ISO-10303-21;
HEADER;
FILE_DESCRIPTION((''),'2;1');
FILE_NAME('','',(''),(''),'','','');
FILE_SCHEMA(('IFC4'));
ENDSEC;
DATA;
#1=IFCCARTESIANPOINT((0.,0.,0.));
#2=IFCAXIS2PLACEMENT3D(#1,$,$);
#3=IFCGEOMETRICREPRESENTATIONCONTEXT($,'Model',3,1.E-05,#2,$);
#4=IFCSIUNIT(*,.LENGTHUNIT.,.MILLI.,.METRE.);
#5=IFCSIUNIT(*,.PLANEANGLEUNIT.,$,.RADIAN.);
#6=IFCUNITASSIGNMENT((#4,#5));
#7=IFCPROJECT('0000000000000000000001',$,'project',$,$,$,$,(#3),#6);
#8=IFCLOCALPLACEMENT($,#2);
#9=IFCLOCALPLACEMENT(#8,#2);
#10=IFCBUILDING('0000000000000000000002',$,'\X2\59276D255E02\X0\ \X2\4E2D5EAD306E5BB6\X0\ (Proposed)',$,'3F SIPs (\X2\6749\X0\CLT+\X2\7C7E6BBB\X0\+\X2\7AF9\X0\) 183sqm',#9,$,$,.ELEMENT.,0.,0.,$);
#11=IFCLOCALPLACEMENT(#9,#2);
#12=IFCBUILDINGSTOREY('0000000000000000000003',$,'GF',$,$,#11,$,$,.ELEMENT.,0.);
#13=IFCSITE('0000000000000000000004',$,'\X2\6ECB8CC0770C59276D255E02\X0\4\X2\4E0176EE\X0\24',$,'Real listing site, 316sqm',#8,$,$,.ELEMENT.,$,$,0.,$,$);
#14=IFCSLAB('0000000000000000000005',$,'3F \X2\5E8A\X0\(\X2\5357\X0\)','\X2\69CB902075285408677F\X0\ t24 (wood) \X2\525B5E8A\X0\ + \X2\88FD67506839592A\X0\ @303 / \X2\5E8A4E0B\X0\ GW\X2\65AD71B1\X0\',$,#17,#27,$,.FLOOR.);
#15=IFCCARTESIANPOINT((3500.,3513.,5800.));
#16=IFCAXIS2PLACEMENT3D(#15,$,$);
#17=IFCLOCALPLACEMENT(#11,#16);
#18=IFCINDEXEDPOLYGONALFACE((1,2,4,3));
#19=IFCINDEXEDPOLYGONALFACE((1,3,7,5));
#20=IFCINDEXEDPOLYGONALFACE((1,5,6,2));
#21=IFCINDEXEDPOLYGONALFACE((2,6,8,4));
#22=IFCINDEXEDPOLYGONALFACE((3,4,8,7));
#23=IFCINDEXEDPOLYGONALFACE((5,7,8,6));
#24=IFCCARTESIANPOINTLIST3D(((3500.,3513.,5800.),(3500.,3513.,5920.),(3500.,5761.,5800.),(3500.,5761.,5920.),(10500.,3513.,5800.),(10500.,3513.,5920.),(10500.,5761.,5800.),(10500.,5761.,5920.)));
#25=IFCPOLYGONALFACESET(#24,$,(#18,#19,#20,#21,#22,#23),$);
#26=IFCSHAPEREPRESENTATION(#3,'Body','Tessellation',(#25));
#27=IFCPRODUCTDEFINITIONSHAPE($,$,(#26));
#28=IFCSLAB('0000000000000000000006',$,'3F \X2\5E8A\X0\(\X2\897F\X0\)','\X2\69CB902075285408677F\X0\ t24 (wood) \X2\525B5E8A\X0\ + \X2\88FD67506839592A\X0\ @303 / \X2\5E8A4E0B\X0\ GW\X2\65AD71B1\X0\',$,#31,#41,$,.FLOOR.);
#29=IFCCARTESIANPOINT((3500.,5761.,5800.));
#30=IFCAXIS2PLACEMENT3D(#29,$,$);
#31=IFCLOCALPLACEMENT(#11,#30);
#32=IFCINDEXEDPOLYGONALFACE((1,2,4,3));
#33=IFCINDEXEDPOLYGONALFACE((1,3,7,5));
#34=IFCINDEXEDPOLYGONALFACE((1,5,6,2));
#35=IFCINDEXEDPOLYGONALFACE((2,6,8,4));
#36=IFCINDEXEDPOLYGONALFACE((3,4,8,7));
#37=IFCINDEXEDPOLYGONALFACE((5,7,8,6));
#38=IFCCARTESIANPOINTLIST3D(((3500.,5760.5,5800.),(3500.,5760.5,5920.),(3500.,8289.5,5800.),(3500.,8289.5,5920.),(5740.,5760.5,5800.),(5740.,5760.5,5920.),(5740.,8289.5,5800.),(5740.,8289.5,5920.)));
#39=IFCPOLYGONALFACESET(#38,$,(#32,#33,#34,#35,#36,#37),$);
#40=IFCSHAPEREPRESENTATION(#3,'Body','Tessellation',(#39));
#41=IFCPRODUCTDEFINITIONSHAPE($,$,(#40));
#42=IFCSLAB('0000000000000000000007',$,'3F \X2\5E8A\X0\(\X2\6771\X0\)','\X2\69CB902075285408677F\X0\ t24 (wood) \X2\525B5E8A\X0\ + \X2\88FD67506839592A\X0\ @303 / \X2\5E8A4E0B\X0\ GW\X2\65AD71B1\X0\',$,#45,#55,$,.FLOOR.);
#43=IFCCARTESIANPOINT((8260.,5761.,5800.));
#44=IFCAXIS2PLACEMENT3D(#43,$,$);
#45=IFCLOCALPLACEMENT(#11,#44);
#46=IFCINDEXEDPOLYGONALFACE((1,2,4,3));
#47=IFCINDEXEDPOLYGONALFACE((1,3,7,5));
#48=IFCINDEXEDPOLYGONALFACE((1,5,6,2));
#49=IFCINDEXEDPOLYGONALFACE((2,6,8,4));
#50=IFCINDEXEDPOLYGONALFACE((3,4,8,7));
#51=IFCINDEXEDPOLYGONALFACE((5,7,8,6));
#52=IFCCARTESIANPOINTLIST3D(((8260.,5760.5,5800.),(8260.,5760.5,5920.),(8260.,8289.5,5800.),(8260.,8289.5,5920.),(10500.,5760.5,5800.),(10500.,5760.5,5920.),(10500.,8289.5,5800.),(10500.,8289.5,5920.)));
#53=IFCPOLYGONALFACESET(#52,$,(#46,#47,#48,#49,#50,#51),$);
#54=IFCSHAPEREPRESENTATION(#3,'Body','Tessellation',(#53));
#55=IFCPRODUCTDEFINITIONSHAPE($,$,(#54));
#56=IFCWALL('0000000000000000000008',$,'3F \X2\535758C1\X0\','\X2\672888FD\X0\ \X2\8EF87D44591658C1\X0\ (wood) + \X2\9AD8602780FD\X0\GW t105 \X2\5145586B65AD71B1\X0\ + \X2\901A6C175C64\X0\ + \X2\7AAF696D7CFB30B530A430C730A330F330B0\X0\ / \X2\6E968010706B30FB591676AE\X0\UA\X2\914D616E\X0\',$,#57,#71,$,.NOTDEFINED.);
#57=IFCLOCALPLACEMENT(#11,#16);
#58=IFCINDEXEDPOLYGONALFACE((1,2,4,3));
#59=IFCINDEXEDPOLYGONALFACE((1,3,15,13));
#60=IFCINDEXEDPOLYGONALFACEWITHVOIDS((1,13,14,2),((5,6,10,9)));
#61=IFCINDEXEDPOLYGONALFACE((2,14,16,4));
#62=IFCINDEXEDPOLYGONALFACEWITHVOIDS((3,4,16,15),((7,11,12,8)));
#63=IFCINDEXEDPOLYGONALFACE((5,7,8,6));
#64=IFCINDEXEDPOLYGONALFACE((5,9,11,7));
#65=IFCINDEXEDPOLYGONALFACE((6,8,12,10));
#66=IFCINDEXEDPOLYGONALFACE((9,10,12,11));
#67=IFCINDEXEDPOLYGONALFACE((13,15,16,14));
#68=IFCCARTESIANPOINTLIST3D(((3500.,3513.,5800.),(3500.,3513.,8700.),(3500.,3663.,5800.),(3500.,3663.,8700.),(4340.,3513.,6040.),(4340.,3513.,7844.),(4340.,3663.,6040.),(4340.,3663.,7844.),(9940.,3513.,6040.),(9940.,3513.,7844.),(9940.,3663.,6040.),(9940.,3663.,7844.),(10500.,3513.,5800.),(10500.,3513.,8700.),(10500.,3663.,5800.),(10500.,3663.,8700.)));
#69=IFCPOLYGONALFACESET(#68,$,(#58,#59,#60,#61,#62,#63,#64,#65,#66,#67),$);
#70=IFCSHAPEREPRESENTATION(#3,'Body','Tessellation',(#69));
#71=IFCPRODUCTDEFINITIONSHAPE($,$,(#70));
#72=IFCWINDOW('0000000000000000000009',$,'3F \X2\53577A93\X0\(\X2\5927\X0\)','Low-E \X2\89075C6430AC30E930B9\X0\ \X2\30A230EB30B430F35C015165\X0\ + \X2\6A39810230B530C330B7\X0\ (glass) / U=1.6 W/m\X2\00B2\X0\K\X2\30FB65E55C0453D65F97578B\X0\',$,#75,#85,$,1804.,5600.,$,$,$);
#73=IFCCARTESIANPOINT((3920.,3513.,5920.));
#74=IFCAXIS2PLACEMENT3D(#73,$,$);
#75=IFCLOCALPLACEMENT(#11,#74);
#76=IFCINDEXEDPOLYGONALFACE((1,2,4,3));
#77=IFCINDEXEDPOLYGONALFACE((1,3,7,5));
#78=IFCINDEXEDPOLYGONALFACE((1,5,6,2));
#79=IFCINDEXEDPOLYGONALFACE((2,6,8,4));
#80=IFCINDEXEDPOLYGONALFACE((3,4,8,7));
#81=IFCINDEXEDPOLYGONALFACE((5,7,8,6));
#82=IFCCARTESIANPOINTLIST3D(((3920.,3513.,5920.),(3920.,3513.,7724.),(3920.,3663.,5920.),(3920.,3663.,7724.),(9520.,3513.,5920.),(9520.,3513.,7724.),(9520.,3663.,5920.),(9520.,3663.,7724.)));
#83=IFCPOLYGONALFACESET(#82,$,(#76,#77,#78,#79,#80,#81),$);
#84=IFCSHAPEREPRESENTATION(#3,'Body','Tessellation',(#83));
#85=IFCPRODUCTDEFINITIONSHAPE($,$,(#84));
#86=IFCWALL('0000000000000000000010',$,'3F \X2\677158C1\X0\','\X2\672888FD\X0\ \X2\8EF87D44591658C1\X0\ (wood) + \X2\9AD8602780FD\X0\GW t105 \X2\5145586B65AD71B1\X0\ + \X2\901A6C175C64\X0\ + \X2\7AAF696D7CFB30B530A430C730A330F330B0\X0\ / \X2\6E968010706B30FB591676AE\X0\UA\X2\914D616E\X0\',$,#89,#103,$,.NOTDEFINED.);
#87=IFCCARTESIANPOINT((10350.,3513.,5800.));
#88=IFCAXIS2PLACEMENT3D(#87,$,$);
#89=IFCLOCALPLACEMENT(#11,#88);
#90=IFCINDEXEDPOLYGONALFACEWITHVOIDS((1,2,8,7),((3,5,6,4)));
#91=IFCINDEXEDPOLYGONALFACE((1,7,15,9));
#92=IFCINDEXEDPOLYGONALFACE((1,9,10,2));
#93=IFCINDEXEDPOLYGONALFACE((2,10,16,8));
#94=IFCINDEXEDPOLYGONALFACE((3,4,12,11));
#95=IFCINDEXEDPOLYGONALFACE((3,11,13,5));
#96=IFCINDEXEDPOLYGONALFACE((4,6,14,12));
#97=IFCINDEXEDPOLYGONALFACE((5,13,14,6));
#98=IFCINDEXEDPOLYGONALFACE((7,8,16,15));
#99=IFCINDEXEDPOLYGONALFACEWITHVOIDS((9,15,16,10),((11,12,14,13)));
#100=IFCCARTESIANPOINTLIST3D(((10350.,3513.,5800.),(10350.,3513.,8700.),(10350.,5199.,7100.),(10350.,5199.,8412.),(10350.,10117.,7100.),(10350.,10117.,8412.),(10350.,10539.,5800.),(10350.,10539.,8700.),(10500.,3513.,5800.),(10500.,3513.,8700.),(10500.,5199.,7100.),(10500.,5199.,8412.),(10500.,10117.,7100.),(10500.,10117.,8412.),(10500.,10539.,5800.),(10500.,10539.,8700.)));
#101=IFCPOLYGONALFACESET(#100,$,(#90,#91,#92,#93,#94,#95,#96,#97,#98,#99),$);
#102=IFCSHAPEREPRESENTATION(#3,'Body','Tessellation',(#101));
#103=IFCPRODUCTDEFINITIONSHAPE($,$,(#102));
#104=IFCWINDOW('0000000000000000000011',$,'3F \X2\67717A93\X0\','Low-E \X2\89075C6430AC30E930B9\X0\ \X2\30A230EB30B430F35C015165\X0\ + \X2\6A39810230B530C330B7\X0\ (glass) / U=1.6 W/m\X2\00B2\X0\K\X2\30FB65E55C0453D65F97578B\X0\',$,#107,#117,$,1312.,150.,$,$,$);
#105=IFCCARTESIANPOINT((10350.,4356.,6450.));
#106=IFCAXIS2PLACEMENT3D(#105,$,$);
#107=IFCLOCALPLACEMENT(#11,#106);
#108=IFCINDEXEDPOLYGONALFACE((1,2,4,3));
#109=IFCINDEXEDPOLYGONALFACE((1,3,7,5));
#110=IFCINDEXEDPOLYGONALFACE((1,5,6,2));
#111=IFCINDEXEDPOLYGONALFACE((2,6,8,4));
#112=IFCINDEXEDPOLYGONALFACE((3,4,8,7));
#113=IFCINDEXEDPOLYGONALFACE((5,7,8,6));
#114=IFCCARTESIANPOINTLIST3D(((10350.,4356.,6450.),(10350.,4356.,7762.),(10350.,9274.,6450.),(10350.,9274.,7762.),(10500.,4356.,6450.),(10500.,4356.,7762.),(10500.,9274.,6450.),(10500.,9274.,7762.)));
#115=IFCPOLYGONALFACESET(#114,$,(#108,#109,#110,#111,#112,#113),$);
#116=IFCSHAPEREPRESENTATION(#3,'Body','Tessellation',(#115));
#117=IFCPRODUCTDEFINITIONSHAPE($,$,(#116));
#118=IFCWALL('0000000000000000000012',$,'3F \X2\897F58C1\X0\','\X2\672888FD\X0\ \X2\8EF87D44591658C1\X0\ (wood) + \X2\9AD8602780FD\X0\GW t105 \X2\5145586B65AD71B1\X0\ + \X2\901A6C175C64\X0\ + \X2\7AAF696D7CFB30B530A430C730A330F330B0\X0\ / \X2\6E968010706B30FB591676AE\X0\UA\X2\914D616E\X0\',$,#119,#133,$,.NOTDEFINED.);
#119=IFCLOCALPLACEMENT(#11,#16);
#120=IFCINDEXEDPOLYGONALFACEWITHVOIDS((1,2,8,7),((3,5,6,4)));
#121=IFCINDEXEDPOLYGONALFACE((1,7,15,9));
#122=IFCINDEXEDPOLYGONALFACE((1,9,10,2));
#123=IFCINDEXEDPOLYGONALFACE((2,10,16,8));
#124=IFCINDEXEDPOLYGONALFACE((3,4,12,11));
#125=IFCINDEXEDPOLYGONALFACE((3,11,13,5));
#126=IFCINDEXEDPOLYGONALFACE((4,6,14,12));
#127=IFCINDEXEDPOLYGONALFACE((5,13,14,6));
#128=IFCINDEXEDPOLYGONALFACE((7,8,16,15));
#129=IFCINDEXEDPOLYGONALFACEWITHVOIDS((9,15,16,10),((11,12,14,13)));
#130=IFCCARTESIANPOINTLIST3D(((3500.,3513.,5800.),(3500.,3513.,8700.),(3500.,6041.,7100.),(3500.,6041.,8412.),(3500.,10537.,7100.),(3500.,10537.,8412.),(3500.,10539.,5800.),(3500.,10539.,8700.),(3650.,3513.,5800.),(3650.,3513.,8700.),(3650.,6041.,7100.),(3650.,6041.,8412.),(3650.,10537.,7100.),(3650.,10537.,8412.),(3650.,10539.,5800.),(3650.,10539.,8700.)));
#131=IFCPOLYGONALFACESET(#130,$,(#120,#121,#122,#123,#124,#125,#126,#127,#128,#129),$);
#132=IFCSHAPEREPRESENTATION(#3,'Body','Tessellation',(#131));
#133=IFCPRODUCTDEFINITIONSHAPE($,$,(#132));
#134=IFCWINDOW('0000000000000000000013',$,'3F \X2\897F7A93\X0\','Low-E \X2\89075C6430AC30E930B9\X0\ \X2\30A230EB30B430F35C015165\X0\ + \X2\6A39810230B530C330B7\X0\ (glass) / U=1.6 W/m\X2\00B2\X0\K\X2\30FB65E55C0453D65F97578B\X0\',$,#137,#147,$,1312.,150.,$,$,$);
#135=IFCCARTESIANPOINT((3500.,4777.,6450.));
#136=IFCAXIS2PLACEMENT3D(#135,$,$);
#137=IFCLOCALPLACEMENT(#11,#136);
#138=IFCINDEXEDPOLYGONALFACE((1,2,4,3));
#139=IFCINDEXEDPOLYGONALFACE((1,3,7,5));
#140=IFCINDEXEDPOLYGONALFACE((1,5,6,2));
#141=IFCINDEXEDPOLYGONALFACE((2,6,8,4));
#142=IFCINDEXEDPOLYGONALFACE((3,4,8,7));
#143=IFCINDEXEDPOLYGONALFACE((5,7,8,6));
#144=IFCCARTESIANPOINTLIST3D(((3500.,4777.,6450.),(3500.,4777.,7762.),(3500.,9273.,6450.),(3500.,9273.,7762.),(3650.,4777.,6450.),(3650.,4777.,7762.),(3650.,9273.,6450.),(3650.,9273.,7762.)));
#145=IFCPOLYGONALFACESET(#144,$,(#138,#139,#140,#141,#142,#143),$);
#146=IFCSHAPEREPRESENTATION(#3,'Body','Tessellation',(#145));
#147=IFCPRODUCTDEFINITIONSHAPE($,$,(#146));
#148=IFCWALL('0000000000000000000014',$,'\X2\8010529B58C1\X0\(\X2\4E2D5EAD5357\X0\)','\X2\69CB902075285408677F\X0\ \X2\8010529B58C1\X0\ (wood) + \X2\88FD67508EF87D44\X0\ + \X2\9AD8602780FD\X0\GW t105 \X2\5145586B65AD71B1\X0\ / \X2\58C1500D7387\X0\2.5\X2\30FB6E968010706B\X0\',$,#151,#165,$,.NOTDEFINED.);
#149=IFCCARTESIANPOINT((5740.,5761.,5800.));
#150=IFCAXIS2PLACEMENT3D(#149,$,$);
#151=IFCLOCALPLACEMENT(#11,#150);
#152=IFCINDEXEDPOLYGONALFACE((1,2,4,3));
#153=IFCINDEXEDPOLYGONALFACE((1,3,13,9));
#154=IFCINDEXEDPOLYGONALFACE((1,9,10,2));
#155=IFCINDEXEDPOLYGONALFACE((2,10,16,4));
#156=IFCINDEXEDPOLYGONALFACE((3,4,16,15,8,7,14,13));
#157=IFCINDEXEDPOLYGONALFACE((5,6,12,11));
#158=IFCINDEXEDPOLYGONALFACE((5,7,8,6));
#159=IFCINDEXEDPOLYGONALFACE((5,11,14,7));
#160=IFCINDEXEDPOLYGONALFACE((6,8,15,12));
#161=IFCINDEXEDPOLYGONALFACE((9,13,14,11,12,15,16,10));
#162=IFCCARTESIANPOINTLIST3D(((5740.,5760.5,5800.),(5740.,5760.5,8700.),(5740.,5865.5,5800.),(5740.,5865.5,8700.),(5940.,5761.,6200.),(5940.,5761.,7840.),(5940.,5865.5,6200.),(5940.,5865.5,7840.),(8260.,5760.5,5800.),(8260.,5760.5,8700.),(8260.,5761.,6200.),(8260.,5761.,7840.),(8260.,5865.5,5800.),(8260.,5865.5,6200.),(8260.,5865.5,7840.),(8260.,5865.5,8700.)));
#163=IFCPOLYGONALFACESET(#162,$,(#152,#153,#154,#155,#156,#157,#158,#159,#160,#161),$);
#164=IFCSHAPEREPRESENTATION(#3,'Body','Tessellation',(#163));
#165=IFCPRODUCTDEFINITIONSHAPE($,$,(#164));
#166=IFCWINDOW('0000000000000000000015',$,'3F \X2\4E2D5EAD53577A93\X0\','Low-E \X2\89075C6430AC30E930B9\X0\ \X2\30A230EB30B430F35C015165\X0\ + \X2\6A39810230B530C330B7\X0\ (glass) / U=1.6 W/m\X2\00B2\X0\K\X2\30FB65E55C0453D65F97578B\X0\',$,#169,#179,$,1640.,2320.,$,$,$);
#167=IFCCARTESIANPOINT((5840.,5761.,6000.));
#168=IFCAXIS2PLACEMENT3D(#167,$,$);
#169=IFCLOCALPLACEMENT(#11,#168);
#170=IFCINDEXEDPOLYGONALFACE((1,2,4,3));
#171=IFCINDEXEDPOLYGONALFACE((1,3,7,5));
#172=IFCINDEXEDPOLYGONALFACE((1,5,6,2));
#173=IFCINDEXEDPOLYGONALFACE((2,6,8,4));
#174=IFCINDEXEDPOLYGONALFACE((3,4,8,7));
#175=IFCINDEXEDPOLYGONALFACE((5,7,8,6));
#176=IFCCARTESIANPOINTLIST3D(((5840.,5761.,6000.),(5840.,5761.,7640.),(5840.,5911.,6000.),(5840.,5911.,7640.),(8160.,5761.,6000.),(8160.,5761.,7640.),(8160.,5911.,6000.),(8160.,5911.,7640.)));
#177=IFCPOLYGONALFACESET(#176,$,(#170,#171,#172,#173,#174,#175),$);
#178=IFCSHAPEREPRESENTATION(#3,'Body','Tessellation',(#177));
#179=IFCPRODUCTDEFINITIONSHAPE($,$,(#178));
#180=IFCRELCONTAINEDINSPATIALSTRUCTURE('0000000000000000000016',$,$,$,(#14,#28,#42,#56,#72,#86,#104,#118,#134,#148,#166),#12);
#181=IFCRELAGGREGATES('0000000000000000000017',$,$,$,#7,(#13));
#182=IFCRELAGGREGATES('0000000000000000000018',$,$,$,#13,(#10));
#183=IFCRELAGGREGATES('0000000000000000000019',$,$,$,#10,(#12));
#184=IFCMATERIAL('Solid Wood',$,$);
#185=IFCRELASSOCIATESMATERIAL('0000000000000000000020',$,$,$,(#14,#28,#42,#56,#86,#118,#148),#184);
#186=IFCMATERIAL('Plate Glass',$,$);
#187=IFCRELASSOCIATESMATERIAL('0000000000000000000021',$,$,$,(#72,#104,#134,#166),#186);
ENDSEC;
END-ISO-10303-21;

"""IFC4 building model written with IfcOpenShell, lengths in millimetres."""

from ifc_helpers import new_model, si_unit, frame, frame_2d, origin, place, context, project, spatial, rectangle, extrude, material, element, fill, save


model = new_model("IFC4")

# Units and contexts
model_context = context("Model", 3, precision=1e-05, world=origin())
ifc_project = project(units=[si_unit("LENGTHUNIT", "METRE", prefix="MILLI"), si_unit("PLANEANGLEUNIT", "RADIAN")], contexts=[model_context])

# Site, building, storey
site_placement = place(None, origin())
site = spatial("IfcSite", under=ifc_project, at=site_placement, Name="滋賀県大津市4丁目24", ObjectType="Real listing site, 316sqm", CompositionType="ELEMENT", RefElevation=0.0)
building_placement = place(site_placement, origin())
building = spatial("IfcBuilding", under=site, at=building_placement, Name="大津市 中庭の家 (Proposed)", ObjectType="3F SIPs (杉CLT+籾殻+竹) 183sqm", CompositionType="ELEMENT", ElevationOfRefHeight=0.0, ElevationOfTerrain=0.0)
storey_placement = place(building_placement, origin())
storey = spatial("IfcBuildingStorey", under=building, at=storey_placement, Name="GF", CompositionType="ELEMENT", Elevation=0.0)

# Slabs
ifc_material_1 = material(Name="Solid Wood")
slab_1_placement = place(storey_placement, frame((3500.0, 3513.0, 5800.0)))
element("IfcSlab", 1, at=slab_1_placement, inside=storey, material=ifc_material_1, Name="3F 床(南)", Description="構造用合板 t24 (wood) 剛床 + 製材根太 @303 / 床下 GW断熱", PredefinedType="FLOOR", context=model_context, shape_type="SweptSolid", body=[
    extrude(rectangle(XDim=7000.0, YDim=2248.0, at=frame_2d((3500.0, 1124.0))), frame((3500.0, 3513.0, 5800.0)), (0.0, 0.0, 1.0), 120.0),
])
slab_2_placement = place(storey_placement, frame((3500.0, 5761.0, 5800.0)))
element("IfcSlab", 2, at=slab_2_placement, inside=storey, material=ifc_material_1, Name="3F 床(西)", Description="構造用合板 t24 (wood) 剛床 + 製材根太 @303 / 床下 GW断熱", PredefinedType="FLOOR", context=model_context, shape_type="SweptSolid", body=[
    extrude(rectangle(XDim=2240.0, YDim=2529.0, at=frame_2d((1120.0, 1264.0))), frame((3500.0, 5761.0, 5800.0)), (0.0, 0.0, 1.0), 120.0),
])
slab_3_placement = place(storey_placement, frame((8260.0, 5761.0, 5800.0)))
element("IfcSlab", 3, at=slab_3_placement, inside=storey, material=ifc_material_1, Name="3F 床(東)", Description="構造用合板 t24 (wood) 剛床 + 製材根太 @303 / 床下 GW断熱", PredefinedType="FLOOR", context=model_context, shape_type="SweptSolid", body=[
    extrude(rectangle(XDim=2240.0, YDim=2529.0, at=frame_2d((1120.0, 1264.0))), frame((8260.0, 5761.0, 5800.0)), (0.0, 0.0, 1.0), 120.0),
])

# Walls, openings, windows
wall_1_placement = place(storey_placement, frame((3500.0, 3513.0, 5800.0)))
wall_1 = element("IfcWall", 4, at=wall_1_placement, inside=storey, material=ifc_material_1, Name="3F 南壁", Description="木製 軸組外壁 (wood) + 高性能GW t105 充填断熱 + 通気層 + 窯業系サイディング / 準耐火・外皮UA配慮", PredefinedType="NOTDEFINED", context=model_context, shape_type="SweptSolid", body=[
    extrude(rectangle(XDim=7000.0, YDim=150.0, at=frame_2d((3500.0, 75.0))), frame((3500.0, 3513.0, 5800.0)), (0.0, 0.0, 1.0), 2900.0),
])
opening_1_placement = place(storey_placement, frame((3920.0, 3513.0, 5920.0)))
opening_1 = element("IfcOpeningElement", 5, at=opening_1_placement, cuts=wall_1, PredefinedType="NOTDEFINED", context=model_context, shape_type="SweptSolid", body=[
    extrude(rectangle(XDim=5600.0, YDim=150.0, at=frame_2d((2800.0, 75.0))), frame((3920.0, 3513.0, 5920.0)), (0.0, 0.0, 1.0), 1804.0),
])
ifc_material_2 = material(Name="Plate Glass")
window_1_placement = place(storey_placement, frame((3920.0, 3513.0, 5920.0)))
window_1 = element("IfcWindow", 6, at=window_1_placement, inside=storey, material=ifc_material_2, Name="3F 南窓(大)", Description="Low-E 複層ガラス アルゴン封入 + 樹脂サッシ (glass) / U=1.6 W/m²K・日射取得型", OverallHeight=1804.0, OverallWidth=5600.0, context=model_context, shape_type="SweptSolid", body=[
    extrude(rectangle(XDim=5600.0, YDim=150.0, at=frame_2d((2800.0, 75.0))), frame((3920.0, 3513.0, 5920.0)), (0.0, 0.0, 1.0), 1804.0),
])
fill(opening_1, window_1)
wall_2_placement = place(storey_placement, frame((10350.0, 3513.0, 5800.0)))
wall_2 = element("IfcWall", 7, at=wall_2_placement, inside=storey, material=ifc_material_1, Name="3F 東壁", Description="木製 軸組外壁 (wood) + 高性能GW t105 充填断熱 + 通気層 + 窯業系サイディング / 準耐火・外皮UA配慮", PredefinedType="NOTDEFINED", context=model_context, shape_type="SweptSolid", body=[
    extrude(rectangle(XDim=150.0, YDim=7026.0, at=frame_2d((75.0, 3513.0))), frame((10350.0, 3513.0, 5800.0)), (0.0, 0.0, 1.0), 2900.0),
])
opening_2_placement = place(storey_placement, frame((10350.0, 4356.0, 6450.0)))
opening_2 = element("IfcOpeningElement", 8, at=opening_2_placement, cuts=wall_2, PredefinedType="NOTDEFINED", context=model_context, shape_type="SweptSolid", body=[
    extrude(rectangle(XDim=150.0, YDim=4918.0, at=frame_2d((75.0, 2459.0))), frame((10350.0, 4356.0, 6450.0)), (0.0, 0.0, 1.0), 1312.0),
])
window_2_placement = place(storey_placement, frame((10350.0, 4356.0, 6450.0)))
window_2 = element("IfcWindow", 9, at=window_2_placement, inside=storey, material=ifc_material_2, Name="3F 東窓", Description="Low-E 複層ガラス アルゴン封入 + 樹脂サッシ (glass) / U=1.6 W/m²K・日射取得型", OverallHeight=1312.0, OverallWidth=150.0, context=model_context, shape_type="SweptSolid", body=[
    extrude(rectangle(XDim=150.0, YDim=4918.0, at=frame_2d((75.0, 2459.0))), frame((10350.0, 4356.0, 6450.0)), (0.0, 0.0, 1.0), 1312.0),
])
fill(opening_2, window_2)
wall_3_placement = place(storey_placement, frame((3500.0, 3513.0, 5800.0)))
wall_3 = element("IfcWall", 10, at=wall_3_placement, inside=storey, material=ifc_material_1, Name="3F 西壁", Description="木製 軸組外壁 (wood) + 高性能GW t105 充填断熱 + 通気層 + 窯業系サイディング / 準耐火・外皮UA配慮", PredefinedType="NOTDEFINED", context=model_context, shape_type="SweptSolid", body=[
    extrude(rectangle(XDim=150.0, YDim=7026.0, at=frame_2d((75.0, 3513.0))), frame((3500.0, 3513.0, 5800.0)), (0.0, 0.0, 1.0), 2900.0),
])
opening_3_placement = place(storey_placement, frame((3500.0, 4777.0, 6450.0)))
opening_3 = element("IfcOpeningElement", 11, at=opening_3_placement, cuts=wall_3, PredefinedType="NOTDEFINED", context=model_context, shape_type="SweptSolid", body=[
    extrude(rectangle(XDim=150.0, YDim=4496.0, at=frame_2d((75.0, 2248.0))), frame((3500.0, 4777.0, 6450.0)), (0.0, 0.0, 1.0), 1312.0),
])
window_3_placement = place(storey_placement, frame((3500.0, 4777.0, 6450.0)))
window_3 = element("IfcWindow", 12, at=window_3_placement, inside=storey, material=ifc_material_2, Name="3F 西窓", Description="Low-E 複層ガラス アルゴン封入 + 樹脂サッシ (glass) / U=1.6 W/m²K・日射取得型", OverallHeight=1312.0, OverallWidth=150.0, context=model_context, shape_type="SweptSolid", body=[
    extrude(rectangle(XDim=150.0, YDim=4496.0, at=frame_2d((75.0, 2248.0))), frame((3500.0, 4777.0, 6450.0)), (0.0, 0.0, 1.0), 1312.0),
])
fill(opening_3, window_3)
wall_4_placement = place(storey_placement, frame((5740.0, 5761.0, 5800.0)))
wall_4 = element("IfcWall", 13, at=wall_4_placement, inside=storey, material=ifc_material_1, Name="耐力壁(中庭南)", Description="構造用合板 耐力壁 (wood) + 製材軸組 + 高性能GW t105 充填断熱 / 壁倍率2.5・準耐火", PredefinedType="NOTDEFINED", context=model_context, shape_type="SweptSolid", body=[
    extrude(rectangle(XDim=2520.0, YDim=105.0, at=frame_2d((1260.0, 52.0))), frame((5740.0, 5761.0, 5800.0)), (0.0, 0.0, 1.0), 2900.0),
])
opening_4_placement = place(storey_placement, frame((5840.0, 5761.0, 6000.0)))
opening_4 = element("IfcOpeningElement", 14, at=opening_4_placement, cuts=wall_4, PredefinedType="NOTDEFINED", context=model_context, shape_type="SweptSolid", body=[
    extrude(rectangle(XDim=2320.0, YDim=150.0, at=frame_2d((1160.0, 75.0))), frame((5840.0, 5761.0, 6000.0)), (0.0, 0.0, 1.0), 1640.0),
])
window_4_placement = place(storey_placement, frame((5840.0, 5761.0, 6000.0)))
window_4 = element("IfcWindow", 15, at=window_4_placement, inside=storey, material=ifc_material_2, Name="3F 中庭南窓", Description="Low-E 複層ガラス アルゴン封入 + 樹脂サッシ (glass) / U=1.6 W/m²K・日射取得型", OverallHeight=1640.0, OverallWidth=2320.0, context=model_context, shape_type="SweptSolid", body=[
    extrude(rectangle(XDim=2320.0, YDim=150.0, at=frame_2d((1160.0, 75.0))), frame((5840.0, 5761.0, 6000.0)), (0.0, 0.0, 1.0), 1640.0),
])
fill(opening_4, window_4)

save(model, "model.ifc")
